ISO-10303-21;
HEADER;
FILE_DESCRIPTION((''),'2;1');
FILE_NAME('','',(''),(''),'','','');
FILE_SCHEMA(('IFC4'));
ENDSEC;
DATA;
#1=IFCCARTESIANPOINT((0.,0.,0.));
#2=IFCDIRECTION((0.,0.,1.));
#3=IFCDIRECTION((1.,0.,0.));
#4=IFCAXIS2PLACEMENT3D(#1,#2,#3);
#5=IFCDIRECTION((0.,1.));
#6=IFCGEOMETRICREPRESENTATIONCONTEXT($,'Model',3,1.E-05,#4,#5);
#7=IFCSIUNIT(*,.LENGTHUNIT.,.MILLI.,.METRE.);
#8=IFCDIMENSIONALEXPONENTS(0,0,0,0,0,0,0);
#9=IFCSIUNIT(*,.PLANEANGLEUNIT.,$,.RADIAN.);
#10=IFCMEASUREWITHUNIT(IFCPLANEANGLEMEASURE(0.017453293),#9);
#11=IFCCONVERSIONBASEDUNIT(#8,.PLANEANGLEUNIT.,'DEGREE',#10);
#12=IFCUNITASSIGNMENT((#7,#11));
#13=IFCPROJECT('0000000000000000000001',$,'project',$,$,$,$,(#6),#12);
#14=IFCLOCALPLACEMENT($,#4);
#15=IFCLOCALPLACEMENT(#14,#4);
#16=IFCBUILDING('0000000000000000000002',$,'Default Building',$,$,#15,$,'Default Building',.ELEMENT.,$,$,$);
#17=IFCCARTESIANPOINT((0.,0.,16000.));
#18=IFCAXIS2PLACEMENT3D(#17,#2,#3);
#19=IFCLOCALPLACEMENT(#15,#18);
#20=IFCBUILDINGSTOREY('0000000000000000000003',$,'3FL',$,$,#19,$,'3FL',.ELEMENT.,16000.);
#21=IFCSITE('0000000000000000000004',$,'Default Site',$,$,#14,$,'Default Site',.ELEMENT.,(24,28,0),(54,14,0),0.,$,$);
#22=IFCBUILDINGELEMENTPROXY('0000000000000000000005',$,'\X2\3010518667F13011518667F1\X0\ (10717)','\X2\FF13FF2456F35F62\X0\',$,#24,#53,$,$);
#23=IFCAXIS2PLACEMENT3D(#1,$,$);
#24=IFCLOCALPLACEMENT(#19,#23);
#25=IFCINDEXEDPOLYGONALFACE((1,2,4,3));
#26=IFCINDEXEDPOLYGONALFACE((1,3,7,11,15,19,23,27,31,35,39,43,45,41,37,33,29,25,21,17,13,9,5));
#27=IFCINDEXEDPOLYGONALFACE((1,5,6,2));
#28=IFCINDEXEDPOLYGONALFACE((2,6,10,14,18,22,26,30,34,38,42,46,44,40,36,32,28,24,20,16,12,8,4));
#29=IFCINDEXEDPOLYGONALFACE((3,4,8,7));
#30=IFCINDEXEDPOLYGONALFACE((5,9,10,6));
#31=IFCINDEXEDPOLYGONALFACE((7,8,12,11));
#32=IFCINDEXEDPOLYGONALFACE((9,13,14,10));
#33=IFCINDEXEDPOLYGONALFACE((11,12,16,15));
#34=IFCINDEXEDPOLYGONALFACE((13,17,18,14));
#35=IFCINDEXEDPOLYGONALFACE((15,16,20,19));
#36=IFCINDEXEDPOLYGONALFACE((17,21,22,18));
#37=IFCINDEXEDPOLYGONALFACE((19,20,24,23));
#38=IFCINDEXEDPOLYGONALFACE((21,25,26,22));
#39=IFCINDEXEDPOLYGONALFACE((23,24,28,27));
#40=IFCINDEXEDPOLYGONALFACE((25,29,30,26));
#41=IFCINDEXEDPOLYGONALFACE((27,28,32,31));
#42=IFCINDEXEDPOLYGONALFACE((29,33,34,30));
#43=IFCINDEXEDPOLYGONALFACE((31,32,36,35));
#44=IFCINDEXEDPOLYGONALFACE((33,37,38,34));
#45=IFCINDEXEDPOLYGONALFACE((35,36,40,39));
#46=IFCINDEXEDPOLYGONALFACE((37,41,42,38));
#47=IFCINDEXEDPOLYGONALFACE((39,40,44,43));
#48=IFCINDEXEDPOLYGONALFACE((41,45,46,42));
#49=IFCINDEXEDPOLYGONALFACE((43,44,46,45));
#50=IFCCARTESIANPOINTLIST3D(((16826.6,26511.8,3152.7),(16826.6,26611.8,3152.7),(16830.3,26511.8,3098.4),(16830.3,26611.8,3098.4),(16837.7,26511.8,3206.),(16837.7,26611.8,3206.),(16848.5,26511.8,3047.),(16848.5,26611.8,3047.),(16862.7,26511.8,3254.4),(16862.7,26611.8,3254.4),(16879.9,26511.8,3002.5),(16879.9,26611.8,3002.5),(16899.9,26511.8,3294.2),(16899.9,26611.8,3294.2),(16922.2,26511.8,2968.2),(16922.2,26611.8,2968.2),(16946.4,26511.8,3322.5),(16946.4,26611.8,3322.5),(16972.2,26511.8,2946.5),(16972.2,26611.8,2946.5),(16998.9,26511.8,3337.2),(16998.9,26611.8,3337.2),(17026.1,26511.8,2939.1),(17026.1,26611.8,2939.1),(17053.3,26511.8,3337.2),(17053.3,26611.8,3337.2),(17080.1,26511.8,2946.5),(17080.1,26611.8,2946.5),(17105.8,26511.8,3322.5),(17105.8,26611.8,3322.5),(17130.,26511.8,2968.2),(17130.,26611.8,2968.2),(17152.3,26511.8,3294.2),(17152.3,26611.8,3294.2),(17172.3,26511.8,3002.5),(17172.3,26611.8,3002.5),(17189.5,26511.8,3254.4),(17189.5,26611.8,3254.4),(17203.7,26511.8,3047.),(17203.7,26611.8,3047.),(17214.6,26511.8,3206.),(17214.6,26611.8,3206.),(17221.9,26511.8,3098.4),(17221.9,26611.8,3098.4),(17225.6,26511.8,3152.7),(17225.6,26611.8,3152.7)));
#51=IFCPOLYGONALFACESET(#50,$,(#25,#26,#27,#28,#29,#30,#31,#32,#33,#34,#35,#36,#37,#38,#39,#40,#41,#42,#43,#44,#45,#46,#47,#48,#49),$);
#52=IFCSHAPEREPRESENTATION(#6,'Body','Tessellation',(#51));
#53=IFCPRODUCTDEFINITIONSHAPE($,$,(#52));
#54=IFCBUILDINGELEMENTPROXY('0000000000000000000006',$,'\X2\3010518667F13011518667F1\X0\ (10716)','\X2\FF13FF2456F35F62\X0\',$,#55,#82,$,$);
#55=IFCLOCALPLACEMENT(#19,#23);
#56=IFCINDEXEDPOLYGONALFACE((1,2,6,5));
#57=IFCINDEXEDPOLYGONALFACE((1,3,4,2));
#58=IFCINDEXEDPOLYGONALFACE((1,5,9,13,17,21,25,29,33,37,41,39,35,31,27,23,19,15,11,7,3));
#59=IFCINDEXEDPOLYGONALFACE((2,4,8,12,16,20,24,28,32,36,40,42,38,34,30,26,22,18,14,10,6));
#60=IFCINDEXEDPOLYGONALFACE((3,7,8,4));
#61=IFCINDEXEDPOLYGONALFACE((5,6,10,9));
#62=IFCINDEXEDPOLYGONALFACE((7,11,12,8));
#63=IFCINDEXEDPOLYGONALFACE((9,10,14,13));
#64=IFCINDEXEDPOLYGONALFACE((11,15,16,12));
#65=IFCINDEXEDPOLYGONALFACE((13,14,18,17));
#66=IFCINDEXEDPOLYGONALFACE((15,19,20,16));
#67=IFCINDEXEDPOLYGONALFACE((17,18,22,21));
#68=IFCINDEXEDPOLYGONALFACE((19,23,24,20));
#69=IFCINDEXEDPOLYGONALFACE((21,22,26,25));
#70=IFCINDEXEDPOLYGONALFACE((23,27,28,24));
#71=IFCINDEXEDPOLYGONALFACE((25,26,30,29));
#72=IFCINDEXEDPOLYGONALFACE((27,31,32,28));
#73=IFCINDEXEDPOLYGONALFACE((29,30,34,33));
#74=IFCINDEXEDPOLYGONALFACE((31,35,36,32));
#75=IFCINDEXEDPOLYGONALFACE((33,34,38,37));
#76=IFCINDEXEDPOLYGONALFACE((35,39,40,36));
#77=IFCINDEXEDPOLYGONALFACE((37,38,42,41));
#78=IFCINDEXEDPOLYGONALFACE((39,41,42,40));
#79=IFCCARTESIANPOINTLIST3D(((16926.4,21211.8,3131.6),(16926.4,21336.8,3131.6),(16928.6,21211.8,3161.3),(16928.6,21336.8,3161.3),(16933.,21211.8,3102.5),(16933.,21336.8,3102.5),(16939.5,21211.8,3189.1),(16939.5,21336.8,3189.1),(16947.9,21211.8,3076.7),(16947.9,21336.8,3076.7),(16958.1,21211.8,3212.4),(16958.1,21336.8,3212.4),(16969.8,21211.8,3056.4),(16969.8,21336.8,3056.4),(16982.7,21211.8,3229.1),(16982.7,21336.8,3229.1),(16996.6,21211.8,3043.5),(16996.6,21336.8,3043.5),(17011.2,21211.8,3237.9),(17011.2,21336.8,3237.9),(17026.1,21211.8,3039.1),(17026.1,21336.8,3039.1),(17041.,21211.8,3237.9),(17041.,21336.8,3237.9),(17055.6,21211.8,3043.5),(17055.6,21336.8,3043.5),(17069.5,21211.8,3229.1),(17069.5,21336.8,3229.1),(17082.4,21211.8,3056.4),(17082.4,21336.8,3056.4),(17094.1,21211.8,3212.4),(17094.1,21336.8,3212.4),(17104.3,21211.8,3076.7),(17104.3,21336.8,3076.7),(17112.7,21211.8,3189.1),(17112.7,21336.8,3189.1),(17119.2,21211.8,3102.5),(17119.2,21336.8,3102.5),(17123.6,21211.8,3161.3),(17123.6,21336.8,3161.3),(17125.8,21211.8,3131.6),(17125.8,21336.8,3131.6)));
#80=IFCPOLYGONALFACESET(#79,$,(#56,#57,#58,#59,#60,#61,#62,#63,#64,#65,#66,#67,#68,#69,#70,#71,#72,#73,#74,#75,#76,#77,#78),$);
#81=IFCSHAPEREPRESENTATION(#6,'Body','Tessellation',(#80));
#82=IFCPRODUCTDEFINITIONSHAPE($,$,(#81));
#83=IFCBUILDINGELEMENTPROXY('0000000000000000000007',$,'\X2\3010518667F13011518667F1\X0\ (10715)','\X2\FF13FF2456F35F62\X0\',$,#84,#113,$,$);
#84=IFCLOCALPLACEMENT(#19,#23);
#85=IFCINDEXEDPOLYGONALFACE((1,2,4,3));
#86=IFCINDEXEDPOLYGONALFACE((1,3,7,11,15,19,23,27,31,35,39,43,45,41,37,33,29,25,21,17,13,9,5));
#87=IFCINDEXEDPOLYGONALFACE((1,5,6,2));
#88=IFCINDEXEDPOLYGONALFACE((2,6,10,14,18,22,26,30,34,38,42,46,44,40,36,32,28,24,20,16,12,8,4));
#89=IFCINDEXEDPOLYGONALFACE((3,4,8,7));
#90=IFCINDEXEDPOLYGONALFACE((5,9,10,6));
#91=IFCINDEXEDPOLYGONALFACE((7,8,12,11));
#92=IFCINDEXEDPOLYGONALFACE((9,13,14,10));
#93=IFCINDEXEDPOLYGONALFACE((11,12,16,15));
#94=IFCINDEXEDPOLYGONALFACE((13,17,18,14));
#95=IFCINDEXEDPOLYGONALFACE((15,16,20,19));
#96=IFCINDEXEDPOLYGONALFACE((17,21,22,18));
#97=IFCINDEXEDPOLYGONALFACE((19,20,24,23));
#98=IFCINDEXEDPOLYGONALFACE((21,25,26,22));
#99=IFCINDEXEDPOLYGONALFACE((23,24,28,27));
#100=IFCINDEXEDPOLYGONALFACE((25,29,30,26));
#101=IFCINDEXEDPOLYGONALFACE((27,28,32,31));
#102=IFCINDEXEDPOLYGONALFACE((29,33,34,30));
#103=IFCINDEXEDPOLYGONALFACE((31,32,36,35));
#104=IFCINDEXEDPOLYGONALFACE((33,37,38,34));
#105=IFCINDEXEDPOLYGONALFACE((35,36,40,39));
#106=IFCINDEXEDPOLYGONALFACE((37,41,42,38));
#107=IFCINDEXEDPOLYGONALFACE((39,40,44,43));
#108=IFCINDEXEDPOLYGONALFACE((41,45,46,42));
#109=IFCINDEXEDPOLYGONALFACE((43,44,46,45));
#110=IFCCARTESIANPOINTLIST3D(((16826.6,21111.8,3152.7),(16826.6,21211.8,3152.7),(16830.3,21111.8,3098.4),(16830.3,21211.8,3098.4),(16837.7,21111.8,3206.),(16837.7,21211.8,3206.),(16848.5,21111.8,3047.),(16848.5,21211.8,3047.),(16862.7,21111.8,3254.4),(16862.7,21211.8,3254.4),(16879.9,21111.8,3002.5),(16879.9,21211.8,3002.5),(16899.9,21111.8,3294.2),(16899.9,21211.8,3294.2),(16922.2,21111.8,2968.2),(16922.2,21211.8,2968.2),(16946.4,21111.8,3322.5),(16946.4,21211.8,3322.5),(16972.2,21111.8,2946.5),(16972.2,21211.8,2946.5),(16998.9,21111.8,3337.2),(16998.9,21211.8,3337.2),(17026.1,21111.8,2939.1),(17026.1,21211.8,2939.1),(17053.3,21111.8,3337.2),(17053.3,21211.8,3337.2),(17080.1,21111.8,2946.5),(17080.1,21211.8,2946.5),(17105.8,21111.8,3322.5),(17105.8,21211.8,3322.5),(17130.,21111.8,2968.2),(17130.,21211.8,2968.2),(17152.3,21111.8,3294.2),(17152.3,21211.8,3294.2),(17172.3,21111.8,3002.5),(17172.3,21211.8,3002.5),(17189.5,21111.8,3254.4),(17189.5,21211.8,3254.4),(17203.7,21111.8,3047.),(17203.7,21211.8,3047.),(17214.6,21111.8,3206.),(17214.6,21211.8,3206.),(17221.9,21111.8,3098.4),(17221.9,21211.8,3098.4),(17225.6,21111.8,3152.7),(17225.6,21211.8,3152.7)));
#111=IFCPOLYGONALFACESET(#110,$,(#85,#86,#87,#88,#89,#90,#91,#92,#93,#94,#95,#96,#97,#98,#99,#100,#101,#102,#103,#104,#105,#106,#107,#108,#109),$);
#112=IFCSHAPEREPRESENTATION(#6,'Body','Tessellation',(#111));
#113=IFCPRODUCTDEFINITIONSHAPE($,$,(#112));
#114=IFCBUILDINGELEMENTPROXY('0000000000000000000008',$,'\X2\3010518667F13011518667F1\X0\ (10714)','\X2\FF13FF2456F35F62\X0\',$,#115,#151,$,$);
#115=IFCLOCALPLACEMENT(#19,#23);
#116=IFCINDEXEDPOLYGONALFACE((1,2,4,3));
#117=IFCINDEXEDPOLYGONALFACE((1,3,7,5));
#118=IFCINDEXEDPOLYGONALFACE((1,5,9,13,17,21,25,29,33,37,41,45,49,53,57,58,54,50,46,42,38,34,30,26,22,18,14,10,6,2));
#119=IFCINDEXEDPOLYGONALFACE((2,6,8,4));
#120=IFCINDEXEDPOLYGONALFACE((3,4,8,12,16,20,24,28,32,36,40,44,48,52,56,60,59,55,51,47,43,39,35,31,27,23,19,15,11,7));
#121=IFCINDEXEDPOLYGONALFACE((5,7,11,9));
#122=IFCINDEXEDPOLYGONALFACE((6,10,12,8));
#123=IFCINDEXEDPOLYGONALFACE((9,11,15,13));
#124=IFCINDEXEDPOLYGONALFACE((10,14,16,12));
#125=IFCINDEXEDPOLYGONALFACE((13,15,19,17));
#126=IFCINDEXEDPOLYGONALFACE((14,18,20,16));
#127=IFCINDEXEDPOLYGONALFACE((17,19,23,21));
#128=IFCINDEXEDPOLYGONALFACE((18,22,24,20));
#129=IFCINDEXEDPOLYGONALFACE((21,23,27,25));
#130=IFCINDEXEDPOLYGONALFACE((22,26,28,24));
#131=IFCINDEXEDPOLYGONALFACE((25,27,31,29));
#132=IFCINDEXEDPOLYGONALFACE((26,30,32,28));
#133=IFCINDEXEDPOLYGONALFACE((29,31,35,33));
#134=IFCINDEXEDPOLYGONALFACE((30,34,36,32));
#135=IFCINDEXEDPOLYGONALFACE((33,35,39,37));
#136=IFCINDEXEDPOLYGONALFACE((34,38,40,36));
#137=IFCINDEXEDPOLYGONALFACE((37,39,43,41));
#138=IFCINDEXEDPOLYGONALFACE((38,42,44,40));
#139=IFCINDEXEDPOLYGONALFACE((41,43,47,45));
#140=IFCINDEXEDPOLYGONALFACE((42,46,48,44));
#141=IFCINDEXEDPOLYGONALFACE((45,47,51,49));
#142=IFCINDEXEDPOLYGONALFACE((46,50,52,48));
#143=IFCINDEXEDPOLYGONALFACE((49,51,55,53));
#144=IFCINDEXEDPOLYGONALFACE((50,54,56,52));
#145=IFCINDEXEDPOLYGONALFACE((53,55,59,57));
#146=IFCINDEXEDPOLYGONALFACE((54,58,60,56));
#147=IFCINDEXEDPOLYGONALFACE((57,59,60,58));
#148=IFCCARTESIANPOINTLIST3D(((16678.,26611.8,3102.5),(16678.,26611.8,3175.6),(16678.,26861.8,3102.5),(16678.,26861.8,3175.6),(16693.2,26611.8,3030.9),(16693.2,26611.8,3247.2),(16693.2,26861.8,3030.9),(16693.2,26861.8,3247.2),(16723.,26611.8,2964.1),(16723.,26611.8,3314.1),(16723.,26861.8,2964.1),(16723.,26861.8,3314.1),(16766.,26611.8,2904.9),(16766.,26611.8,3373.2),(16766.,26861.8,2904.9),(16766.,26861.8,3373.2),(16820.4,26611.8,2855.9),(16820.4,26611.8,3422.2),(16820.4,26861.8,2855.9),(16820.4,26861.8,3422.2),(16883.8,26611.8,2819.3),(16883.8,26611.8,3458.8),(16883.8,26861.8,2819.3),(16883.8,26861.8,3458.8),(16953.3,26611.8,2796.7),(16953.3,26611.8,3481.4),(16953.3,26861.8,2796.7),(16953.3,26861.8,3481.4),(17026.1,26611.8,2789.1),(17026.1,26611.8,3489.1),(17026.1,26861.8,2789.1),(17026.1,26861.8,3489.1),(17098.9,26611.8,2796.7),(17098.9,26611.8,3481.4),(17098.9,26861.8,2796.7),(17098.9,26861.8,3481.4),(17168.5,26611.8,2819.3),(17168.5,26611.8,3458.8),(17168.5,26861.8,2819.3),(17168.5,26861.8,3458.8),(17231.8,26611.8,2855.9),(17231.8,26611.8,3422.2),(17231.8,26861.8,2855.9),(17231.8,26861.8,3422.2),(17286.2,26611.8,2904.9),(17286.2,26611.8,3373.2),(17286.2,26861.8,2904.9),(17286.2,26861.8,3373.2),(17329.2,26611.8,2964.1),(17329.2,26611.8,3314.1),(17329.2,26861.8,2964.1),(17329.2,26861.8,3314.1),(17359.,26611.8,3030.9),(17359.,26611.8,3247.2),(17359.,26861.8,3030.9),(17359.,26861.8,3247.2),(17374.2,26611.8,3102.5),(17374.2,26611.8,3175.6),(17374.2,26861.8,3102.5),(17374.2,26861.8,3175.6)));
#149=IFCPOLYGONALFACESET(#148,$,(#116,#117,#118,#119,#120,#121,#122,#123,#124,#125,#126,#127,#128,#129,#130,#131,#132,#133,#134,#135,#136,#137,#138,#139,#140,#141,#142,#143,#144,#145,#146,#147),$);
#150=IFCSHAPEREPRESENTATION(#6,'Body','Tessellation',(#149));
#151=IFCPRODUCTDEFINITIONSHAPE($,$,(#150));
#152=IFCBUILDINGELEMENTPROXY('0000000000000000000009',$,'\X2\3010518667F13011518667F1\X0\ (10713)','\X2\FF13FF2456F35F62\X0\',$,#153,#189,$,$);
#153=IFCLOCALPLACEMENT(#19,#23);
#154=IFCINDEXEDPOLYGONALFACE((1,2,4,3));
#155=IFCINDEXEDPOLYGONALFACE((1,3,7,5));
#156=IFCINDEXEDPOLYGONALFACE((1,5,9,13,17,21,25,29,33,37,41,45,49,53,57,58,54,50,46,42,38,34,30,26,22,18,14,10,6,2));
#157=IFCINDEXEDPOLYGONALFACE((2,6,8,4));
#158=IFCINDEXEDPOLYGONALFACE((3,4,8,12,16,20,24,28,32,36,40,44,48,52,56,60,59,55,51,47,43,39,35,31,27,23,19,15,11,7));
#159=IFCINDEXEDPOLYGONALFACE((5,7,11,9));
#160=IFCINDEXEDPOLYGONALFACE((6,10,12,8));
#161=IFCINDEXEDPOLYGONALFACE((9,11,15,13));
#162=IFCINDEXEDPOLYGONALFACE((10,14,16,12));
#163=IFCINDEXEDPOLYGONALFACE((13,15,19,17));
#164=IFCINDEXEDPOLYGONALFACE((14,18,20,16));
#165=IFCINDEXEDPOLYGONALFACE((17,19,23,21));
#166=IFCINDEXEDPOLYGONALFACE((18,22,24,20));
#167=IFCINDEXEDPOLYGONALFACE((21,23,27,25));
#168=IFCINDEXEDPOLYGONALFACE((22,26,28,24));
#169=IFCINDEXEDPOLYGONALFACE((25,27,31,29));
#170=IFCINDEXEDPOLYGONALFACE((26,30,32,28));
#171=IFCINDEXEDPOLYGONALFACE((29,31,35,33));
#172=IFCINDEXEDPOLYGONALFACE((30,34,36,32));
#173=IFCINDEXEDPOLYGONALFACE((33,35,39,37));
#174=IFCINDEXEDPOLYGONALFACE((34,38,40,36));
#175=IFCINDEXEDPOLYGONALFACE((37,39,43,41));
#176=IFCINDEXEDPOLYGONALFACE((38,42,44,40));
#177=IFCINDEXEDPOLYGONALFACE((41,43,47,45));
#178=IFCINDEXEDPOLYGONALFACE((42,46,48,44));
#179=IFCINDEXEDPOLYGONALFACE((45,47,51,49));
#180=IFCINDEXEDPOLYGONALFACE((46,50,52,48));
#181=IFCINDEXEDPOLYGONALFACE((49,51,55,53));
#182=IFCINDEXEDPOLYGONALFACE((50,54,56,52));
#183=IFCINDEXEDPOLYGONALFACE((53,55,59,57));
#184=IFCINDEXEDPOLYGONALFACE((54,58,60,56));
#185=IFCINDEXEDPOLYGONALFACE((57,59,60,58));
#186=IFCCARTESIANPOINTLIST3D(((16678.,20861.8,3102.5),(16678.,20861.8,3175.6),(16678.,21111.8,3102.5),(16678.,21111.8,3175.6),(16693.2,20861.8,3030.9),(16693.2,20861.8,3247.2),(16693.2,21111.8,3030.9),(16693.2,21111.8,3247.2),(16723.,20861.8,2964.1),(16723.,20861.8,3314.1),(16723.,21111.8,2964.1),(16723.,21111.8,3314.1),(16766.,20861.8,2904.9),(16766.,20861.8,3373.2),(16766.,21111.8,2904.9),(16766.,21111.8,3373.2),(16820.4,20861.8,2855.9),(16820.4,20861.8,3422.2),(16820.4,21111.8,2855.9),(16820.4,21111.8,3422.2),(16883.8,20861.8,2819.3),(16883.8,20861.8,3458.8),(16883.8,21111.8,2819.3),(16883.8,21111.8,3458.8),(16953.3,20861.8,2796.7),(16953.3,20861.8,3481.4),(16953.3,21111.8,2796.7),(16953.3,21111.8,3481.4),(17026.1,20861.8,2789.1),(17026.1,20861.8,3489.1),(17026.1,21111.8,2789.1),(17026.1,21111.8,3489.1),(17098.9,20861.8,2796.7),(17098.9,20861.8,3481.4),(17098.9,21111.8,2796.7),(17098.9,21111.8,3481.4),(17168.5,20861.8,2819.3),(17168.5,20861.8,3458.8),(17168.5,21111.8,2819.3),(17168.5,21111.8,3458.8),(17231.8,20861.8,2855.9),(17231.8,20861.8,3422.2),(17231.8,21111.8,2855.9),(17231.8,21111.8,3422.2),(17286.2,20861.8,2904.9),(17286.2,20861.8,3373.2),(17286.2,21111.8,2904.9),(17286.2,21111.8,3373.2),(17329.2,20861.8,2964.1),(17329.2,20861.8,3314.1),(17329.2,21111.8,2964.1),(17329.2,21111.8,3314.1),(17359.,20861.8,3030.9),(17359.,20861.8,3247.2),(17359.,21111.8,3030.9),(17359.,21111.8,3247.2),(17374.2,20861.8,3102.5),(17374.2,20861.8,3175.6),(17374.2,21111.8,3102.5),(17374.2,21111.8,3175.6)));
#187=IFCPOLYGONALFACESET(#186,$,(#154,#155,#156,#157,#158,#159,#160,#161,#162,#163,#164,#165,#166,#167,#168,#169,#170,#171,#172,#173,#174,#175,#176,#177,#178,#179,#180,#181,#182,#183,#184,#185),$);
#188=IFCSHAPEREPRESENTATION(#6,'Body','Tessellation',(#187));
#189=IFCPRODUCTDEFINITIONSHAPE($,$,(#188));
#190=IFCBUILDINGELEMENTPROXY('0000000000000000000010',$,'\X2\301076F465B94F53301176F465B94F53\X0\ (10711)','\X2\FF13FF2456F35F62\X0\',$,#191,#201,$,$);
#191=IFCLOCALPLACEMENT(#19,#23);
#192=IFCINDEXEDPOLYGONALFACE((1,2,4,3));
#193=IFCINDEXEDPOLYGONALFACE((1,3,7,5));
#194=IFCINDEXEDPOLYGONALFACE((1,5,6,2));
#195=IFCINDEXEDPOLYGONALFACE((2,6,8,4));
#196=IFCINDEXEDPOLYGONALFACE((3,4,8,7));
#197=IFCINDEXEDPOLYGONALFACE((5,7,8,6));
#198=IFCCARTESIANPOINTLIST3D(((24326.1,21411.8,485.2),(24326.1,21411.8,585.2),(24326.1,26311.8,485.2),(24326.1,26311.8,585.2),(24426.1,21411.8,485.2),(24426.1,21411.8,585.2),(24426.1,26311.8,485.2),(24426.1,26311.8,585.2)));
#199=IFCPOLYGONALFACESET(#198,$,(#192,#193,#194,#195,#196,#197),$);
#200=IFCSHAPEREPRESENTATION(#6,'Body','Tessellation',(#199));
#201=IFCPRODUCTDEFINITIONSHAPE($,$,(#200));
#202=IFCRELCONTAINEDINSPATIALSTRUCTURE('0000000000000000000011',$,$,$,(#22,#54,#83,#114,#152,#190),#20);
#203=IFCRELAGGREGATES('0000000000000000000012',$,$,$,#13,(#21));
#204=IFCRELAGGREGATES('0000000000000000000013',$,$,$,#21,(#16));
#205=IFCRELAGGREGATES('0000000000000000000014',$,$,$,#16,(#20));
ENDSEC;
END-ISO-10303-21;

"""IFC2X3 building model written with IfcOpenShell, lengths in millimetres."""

from ifc_helpers import new_model, entity, si_unit, converted_unit, direction, frame, origin_with_axes, origin_2d_with_axis, place, context, project, spatial, rectangle, circle, extrude, source, transform, mapped, element, save


model = new_model("IFC2X3")

# Units and contexts
model_context = context("Model", 3, precision=1e-05, world=origin_with_axes(), true_north=direction((0.0, 1.0)))
ifc_project = project(units=[si_unit("LENGTHUNIT", "METRE", prefix="MILLI"), converted_unit("PLANEANGLEUNIT", "DEGREE", entity("IfcPlaneAngleMeasure", 0.017453293), si_unit("PLANEANGLEUNIT", "RADIAN"), dimensions=[0, 0, 0, 0, 0, 0, 0])], contexts=[model_context])

# Site, building, storey
site_placement = place(None, origin_with_axes())
site = spatial("IfcSite", under=ifc_project, at=site_placement, Name="Default Site", LongName="Default Site", CompositionType="ELEMENT", RefLatitude=(24, 28, 0), RefLongitude=(54, 14, 0), RefElevation=0.0)
building_placement = place(site_placement, origin_with_axes())
building = spatial("IfcBuilding", under=site, at=building_placement, Name="Default Building", LongName="Default Building", CompositionType="ELEMENT")
storey_placement = place(building_placement, frame((0.0, 0.0, 16000.0), z_axis=(0.0, 0.0, 1.0), x_axis=(1.0, 0.0, 0.0)))
storey = spatial("IfcBuildingStorey", under=building, at=storey_placement, Name="3FL", LongName="3FL", CompositionType="ELEMENT", Elevation=16000.0)

# Building element proxies
shared_shape_1 = source(origin_with_axes(), model_context, "Body", "SweptSolid", [
    extrude(circle(Radius=200.0, at=origin_2d_with_axis()), frame((0.0, 0.0, 0.0), z_axis=(0.0, 0.0, 1.0), x_axis=(1.0, 0.0, 0.0)), (0.0, 0.0, 1.0), 100.0),
])
proxy_1_placement = place(storey_placement, frame((17026.1, 26511.8, 3139.1), z_axis=(0.0, 1.0, 0.0), x_axis=(0.0, 0.0, -1.0)))
element("IfcBuildingElementProxy", 1, at=proxy_1_placement, inside=storey, Name="【円柱】円柱 (10717)", Description="３Ｄ図形", context=model_context, shape_type="MappedRepresentation", body=[
    mapped(shared_shape_1, transform((0.0, 0.0, 0.0))),
])
shared_shape_2 = source(origin_with_axes(), model_context, "Body", "SweptSolid", [
    extrude(circle(Radius=100.0, at=origin_2d_with_axis()), frame((0.0, 0.0, 0.0), z_axis=(0.0, 0.0, 1.0), x_axis=(1.0, 0.0, 0.0)), (0.0, 0.0, 1.0), 125.0),
])
proxy_2_placement = place(storey_placement, frame((17026.1, 21211.8, 3139.1), z_axis=(0.0, 1.0, 0.0), x_axis=(0.0, 0.0, -1.0)))
element("IfcBuildingElementProxy", 2, at=proxy_2_placement, inside=storey, Name="【円柱】円柱 (10716)", Description="３Ｄ図形", context=model_context, shape_type="MappedRepresentation", body=[
    mapped(shared_shape_2, transform((0.0, 0.0, 0.0))),
])
shared_shape_3 = source(origin_with_axes(), model_context, "Body", "SweptSolid", [
    extrude(circle(Radius=200.0, at=origin_2d_with_axis()), frame((0.0, 0.0, 0.0), z_axis=(0.0, 0.0, 1.0), x_axis=(1.0, 0.0, 0.0)), (0.0, 0.0, 1.0), 100.0),
])
proxy_3_placement = place(storey_placement, frame((17026.1, 21111.8, 3139.1), z_axis=(0.0, 1.0, 0.0), x_axis=(0.0, 0.0, -1.0)))
element("IfcBuildingElementProxy", 3, at=proxy_3_placement, inside=storey, Name="【円柱】円柱 (10715)", Description="３Ｄ図形", context=model_context, shape_type="MappedRepresentation", body=[
    mapped(shared_shape_3, transform((0.0, 0.0, 0.0))),
])
shared_shape_4 = source(origin_with_axes(), model_context, "Body", "SweptSolid", [
    extrude(circle(Radius=350.0, at=origin_2d_with_axis()), frame((0.0, 0.0, 0.0), z_axis=(0.0, 0.0, 1.0), x_axis=(1.0, 0.0, 0.0)), (0.0, 0.0, 1.0), 250.0),
])
proxy_4_placement = place(storey_placement, frame((17026.1, 26611.8, 3139.1), z_axis=(0.0, 1.0, 0.0), x_axis=(0.0, 0.0, -1.0)))
element("IfcBuildingElementProxy", 4, at=proxy_4_placement, inside=storey, Name="【円柱】円柱 (10714)", Description="３Ｄ図形", context=model_context, shape_type="MappedRepresentation", body=[
    mapped(shared_shape_4, transform((0.0, 0.0, 0.0))),
])
shared_shape_5 = source(origin_with_axes(), model_context, "Body", "SweptSolid", [
    extrude(circle(Radius=350.0, at=origin_2d_with_axis()), frame((0.0, 0.0, 0.0), z_axis=(0.0, 0.0, 1.0), x_axis=(1.0, 0.0, 0.0)), (0.0, 0.0, 1.0), 250.0),
])
proxy_5_placement = place(storey_placement, frame((17026.1, 20861.8, 3139.1), z_axis=(0.0, 1.0, 0.0), x_axis=(0.0, 0.0, -1.0)))
element("IfcBuildingElementProxy", 5, at=proxy_5_placement, inside=storey, Name="【円柱】円柱 (10713)", Description="３Ｄ図形", context=model_context, shape_type="MappedRepresentation", body=[
    mapped(shared_shape_5, transform((0.0, 0.0, 0.0))),
])
shared_shape_6 = source(origin_with_axes(), model_context, "Body", "SweptSolid", [
    extrude(rectangle(XDim=100.0, YDim=4900.0, at=origin_2d_with_axis()), origin_with_axes(), (0.0, 0.0, 1.0), 100.0),
])
proxy_6_placement = place(storey_placement, frame((24376.1, 23861.8, 485.2), z_axis=(0.0, 0.0, 1.0), x_axis=(1.0, 0.0, 0.0)))
element("IfcBuildingElementProxy", 6, at=proxy_6_placement, inside=storey, Name="【直方体】直方体 (10711)", Description="３Ｄ図形", context=model_context, shape_type="MappedRepresentation", body=[
    mapped(shared_shape_6, transform((0.0, 0.0, 0.0))),
])

save(model, "model.ifc")
